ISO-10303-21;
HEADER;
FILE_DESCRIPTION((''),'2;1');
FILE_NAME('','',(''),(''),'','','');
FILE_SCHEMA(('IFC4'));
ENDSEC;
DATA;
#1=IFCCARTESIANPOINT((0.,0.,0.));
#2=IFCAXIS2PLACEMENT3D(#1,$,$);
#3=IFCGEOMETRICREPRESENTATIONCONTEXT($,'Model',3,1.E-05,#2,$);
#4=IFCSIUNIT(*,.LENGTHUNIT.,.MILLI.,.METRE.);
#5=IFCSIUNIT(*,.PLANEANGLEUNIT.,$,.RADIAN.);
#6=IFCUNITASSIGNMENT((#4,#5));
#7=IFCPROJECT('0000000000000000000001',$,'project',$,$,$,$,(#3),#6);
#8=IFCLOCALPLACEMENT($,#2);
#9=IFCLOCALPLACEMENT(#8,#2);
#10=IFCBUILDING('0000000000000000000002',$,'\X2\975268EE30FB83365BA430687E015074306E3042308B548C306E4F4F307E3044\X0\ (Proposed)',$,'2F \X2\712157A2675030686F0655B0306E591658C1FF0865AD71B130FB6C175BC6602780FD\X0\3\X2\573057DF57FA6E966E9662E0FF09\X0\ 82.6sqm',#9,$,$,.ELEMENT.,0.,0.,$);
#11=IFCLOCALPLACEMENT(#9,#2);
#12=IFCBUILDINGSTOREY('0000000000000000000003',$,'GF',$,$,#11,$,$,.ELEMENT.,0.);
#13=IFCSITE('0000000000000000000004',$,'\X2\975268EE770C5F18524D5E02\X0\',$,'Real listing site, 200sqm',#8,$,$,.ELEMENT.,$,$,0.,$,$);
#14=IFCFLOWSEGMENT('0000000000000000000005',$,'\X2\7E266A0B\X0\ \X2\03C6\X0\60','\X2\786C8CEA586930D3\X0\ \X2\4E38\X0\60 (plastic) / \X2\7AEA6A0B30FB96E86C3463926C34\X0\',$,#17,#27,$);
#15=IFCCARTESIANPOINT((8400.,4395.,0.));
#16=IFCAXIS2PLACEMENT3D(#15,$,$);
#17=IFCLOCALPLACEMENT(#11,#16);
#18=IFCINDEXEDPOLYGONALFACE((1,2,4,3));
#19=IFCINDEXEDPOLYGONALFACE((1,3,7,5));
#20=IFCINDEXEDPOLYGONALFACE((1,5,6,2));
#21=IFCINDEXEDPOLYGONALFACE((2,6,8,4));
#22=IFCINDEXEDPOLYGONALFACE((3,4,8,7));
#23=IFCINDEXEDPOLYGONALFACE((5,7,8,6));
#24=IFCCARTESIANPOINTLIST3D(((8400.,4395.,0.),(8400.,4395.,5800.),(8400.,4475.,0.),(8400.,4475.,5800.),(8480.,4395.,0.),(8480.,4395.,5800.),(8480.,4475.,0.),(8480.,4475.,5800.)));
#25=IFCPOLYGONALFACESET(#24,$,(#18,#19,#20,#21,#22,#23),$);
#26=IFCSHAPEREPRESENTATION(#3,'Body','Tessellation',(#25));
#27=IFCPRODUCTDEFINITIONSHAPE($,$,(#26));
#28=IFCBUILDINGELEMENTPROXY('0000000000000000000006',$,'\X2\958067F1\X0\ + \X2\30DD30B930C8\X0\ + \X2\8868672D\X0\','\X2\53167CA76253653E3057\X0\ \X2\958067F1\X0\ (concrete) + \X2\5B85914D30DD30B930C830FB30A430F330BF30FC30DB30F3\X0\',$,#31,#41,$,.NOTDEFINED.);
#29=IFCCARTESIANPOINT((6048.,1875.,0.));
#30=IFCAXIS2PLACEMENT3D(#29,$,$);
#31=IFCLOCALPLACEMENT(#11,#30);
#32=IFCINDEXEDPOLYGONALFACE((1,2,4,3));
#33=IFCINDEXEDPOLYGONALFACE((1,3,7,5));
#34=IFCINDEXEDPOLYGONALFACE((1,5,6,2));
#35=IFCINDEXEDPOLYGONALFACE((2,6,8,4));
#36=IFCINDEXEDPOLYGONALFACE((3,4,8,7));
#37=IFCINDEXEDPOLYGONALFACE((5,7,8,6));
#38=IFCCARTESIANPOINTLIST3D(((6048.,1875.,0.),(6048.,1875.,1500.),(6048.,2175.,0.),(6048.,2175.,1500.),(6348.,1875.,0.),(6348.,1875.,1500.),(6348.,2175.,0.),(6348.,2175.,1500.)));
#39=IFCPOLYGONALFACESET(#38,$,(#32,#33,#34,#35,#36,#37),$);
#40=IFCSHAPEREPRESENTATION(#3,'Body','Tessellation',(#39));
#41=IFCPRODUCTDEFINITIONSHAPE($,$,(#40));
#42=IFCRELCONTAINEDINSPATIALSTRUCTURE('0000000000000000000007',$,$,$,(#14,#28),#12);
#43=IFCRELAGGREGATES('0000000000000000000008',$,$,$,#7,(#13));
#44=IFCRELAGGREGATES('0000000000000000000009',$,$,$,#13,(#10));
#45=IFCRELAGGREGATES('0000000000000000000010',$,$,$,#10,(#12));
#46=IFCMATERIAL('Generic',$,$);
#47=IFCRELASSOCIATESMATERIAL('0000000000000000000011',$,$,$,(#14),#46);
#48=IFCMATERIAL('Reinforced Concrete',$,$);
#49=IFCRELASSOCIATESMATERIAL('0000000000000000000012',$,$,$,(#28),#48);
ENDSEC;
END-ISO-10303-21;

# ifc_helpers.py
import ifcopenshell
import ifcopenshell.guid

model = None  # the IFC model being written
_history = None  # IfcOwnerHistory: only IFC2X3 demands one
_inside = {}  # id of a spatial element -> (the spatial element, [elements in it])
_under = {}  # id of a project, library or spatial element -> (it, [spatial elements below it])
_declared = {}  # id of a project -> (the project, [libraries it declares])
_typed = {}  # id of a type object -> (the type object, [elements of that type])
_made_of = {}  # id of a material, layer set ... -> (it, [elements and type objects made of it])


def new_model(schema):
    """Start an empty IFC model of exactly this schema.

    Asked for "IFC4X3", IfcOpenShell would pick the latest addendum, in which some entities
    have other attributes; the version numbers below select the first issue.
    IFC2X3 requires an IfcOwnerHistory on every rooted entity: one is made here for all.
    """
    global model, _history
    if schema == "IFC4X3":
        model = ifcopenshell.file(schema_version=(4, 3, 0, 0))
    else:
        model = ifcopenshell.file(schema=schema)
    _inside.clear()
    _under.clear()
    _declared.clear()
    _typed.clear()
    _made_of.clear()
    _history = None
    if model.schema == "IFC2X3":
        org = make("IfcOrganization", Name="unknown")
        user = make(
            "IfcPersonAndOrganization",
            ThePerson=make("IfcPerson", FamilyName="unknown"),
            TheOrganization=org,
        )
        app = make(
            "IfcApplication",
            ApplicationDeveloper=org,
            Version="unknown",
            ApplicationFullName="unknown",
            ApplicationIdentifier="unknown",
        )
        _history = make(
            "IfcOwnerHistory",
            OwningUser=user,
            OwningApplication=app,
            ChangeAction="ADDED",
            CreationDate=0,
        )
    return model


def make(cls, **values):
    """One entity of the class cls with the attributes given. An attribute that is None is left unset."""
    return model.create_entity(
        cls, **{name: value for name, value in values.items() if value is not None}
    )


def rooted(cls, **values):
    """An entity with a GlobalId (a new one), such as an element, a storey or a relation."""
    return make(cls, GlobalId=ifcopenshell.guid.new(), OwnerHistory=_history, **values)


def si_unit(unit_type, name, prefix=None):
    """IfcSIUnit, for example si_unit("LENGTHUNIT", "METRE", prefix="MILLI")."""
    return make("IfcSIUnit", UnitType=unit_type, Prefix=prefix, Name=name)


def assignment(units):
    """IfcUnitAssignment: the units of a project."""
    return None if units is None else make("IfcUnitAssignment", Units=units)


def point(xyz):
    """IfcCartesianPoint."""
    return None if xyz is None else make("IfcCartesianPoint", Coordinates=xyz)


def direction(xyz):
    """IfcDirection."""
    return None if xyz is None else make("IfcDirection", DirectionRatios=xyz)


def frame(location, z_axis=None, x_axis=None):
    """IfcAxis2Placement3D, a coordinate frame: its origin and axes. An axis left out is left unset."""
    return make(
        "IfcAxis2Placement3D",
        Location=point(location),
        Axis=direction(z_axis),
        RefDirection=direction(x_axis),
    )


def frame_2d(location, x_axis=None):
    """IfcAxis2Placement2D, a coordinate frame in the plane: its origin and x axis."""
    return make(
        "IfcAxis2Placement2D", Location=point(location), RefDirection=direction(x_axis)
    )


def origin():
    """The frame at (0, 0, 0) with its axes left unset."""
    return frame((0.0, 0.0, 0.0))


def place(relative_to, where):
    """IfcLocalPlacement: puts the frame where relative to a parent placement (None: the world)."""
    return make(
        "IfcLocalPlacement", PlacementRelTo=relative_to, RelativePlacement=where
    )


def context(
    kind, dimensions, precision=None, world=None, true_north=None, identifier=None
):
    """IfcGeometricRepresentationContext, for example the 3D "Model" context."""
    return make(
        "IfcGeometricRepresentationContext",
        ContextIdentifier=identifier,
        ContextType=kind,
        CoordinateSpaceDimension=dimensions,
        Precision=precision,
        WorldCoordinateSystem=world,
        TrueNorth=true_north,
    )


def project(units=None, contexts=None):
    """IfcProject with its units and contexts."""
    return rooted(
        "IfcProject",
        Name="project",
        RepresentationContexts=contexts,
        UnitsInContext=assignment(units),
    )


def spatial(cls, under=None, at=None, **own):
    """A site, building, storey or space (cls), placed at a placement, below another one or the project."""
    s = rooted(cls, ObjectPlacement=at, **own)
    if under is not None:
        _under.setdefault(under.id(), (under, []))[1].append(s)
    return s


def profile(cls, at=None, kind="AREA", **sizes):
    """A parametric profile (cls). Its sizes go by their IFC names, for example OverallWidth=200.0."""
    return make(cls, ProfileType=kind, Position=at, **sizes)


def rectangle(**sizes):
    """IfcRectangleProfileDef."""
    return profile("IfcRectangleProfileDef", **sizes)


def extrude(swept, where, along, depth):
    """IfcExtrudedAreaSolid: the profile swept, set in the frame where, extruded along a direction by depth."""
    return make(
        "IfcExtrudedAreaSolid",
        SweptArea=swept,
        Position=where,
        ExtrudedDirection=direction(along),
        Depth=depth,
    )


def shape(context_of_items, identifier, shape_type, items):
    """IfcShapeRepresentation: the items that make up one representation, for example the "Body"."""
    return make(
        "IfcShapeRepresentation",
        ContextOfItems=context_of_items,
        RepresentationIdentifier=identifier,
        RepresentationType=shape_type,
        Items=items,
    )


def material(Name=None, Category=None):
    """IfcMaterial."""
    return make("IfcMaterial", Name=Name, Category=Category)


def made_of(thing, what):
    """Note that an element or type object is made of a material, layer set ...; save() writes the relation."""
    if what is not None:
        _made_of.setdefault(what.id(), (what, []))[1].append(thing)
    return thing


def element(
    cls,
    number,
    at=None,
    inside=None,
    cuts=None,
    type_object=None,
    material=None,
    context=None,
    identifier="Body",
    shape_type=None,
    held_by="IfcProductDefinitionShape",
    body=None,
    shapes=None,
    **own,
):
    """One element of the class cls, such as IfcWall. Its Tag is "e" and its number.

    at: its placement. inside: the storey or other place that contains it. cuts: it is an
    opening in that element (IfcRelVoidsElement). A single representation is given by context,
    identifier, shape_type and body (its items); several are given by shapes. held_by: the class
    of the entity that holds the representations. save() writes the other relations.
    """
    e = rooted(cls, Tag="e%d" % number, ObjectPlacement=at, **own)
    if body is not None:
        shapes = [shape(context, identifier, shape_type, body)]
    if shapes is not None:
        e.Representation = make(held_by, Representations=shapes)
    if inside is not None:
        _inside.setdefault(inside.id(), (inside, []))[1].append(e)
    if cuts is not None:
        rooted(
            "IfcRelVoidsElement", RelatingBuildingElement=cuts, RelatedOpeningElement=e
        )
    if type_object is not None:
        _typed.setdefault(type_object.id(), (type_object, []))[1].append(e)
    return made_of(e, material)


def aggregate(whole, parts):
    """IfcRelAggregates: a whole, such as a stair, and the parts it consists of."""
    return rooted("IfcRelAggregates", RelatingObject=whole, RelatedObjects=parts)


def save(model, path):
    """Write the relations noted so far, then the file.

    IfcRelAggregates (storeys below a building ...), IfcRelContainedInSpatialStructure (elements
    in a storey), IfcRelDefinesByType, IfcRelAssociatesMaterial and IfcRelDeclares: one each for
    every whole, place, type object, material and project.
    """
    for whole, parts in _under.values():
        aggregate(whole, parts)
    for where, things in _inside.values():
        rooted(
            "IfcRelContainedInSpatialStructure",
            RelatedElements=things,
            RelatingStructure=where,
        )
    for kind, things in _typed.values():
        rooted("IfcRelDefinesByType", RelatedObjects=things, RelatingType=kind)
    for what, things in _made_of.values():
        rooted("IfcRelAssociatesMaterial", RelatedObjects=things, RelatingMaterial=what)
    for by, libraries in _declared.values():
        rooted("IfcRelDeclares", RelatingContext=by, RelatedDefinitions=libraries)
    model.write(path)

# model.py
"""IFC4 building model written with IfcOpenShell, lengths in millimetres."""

from ifc_helpers import new_model, si_unit, frame, frame_2d, origin, place, context, project, spatial, rectangle, extrude, material, element, save


model = new_model("IFC4")

# Units and contexts
model_context = context("Model", 3, precision=1e-05, world=origin())
ifc_project = project(units=[si_unit("LENGTHUNIT", "METRE", prefix="MILLI"), si_unit("PLANEANGLEUNIT", "RADIAN")], contexts=[model_context])

# Site, building, storey
site_placement = place(None, origin())
site = spatial("IfcSite", under=ifc_project, at=site_placement, Name="青森県弘前市", ObjectType="Real listing site, 200sqm", CompositionType="ELEMENT", RefElevation=0.0)
building_placement = place(site_placement, origin())
building = spatial("IfcBuilding", under=site, at=building_placement, Name="青森・茶室と縁側のある和の住まい (Proposed)", ObjectType="2F 無垢材と漆喰の外壁（断熱・気密性能3地域基準準拠） 82.6sqm", CompositionType="ELEMENT", ElevationOfRefHeight=0.0, ElevationOfTerrain=0.0)
storey_placement = place(building_placement, origin())
storey = spatial("IfcBuildingStorey", under=building, at=storey_placement, Name="GF", CompositionType="ELEMENT", Elevation=0.0)

# Shared definitions
ifc_material_1 = material(Name="Reinforced Concrete")

# Flow segment
ifc_material_2 = material(Name="Generic")
flow_segment_1_placement = place(storey_placement, frame((8400.0, 4395.0, 0.0)))
element("IfcFlowSegment", 1, at=flow_segment_1_placement, inside=storey, material=ifc_material_2, Name="縦樋 φ60", Description="硬質塩ビ 丸60 (plastic) / 竪樋・雨水排水", context=model_context, shape_type="SweptSolid", body=[
    extrude(rectangle(XDim=80.0, YDim=80.0, at=frame_2d((40.0, 40.0))), frame((8400.0, 4395.0, 0.0)), (0.0, 0.0, 1.0), 5800.0),
])

# Building element proxy
proxy_placement = place(storey_placement, frame((6048.0, 1875.0, 0.0)))
element("IfcBuildingElementProxy", 2, at=proxy_placement, inside=storey, material=ifc_material_1, Name="門柱 + ポスト + 表札", Description="化粧打放し 門柱 (concrete) + 宅配ポスト・インターホン", PredefinedType="NOTDEFINED", context=model_context, shape_type="SweptSolid", body=[
    extrude(rectangle(XDim=300.0, YDim=300.0, at=frame_2d((150.0, 150.0))), frame((6048.0, 1875.0, 0.0)), (0.0, 0.0, 1.0), 1500.0),
])

save(model, "model.ifc")
